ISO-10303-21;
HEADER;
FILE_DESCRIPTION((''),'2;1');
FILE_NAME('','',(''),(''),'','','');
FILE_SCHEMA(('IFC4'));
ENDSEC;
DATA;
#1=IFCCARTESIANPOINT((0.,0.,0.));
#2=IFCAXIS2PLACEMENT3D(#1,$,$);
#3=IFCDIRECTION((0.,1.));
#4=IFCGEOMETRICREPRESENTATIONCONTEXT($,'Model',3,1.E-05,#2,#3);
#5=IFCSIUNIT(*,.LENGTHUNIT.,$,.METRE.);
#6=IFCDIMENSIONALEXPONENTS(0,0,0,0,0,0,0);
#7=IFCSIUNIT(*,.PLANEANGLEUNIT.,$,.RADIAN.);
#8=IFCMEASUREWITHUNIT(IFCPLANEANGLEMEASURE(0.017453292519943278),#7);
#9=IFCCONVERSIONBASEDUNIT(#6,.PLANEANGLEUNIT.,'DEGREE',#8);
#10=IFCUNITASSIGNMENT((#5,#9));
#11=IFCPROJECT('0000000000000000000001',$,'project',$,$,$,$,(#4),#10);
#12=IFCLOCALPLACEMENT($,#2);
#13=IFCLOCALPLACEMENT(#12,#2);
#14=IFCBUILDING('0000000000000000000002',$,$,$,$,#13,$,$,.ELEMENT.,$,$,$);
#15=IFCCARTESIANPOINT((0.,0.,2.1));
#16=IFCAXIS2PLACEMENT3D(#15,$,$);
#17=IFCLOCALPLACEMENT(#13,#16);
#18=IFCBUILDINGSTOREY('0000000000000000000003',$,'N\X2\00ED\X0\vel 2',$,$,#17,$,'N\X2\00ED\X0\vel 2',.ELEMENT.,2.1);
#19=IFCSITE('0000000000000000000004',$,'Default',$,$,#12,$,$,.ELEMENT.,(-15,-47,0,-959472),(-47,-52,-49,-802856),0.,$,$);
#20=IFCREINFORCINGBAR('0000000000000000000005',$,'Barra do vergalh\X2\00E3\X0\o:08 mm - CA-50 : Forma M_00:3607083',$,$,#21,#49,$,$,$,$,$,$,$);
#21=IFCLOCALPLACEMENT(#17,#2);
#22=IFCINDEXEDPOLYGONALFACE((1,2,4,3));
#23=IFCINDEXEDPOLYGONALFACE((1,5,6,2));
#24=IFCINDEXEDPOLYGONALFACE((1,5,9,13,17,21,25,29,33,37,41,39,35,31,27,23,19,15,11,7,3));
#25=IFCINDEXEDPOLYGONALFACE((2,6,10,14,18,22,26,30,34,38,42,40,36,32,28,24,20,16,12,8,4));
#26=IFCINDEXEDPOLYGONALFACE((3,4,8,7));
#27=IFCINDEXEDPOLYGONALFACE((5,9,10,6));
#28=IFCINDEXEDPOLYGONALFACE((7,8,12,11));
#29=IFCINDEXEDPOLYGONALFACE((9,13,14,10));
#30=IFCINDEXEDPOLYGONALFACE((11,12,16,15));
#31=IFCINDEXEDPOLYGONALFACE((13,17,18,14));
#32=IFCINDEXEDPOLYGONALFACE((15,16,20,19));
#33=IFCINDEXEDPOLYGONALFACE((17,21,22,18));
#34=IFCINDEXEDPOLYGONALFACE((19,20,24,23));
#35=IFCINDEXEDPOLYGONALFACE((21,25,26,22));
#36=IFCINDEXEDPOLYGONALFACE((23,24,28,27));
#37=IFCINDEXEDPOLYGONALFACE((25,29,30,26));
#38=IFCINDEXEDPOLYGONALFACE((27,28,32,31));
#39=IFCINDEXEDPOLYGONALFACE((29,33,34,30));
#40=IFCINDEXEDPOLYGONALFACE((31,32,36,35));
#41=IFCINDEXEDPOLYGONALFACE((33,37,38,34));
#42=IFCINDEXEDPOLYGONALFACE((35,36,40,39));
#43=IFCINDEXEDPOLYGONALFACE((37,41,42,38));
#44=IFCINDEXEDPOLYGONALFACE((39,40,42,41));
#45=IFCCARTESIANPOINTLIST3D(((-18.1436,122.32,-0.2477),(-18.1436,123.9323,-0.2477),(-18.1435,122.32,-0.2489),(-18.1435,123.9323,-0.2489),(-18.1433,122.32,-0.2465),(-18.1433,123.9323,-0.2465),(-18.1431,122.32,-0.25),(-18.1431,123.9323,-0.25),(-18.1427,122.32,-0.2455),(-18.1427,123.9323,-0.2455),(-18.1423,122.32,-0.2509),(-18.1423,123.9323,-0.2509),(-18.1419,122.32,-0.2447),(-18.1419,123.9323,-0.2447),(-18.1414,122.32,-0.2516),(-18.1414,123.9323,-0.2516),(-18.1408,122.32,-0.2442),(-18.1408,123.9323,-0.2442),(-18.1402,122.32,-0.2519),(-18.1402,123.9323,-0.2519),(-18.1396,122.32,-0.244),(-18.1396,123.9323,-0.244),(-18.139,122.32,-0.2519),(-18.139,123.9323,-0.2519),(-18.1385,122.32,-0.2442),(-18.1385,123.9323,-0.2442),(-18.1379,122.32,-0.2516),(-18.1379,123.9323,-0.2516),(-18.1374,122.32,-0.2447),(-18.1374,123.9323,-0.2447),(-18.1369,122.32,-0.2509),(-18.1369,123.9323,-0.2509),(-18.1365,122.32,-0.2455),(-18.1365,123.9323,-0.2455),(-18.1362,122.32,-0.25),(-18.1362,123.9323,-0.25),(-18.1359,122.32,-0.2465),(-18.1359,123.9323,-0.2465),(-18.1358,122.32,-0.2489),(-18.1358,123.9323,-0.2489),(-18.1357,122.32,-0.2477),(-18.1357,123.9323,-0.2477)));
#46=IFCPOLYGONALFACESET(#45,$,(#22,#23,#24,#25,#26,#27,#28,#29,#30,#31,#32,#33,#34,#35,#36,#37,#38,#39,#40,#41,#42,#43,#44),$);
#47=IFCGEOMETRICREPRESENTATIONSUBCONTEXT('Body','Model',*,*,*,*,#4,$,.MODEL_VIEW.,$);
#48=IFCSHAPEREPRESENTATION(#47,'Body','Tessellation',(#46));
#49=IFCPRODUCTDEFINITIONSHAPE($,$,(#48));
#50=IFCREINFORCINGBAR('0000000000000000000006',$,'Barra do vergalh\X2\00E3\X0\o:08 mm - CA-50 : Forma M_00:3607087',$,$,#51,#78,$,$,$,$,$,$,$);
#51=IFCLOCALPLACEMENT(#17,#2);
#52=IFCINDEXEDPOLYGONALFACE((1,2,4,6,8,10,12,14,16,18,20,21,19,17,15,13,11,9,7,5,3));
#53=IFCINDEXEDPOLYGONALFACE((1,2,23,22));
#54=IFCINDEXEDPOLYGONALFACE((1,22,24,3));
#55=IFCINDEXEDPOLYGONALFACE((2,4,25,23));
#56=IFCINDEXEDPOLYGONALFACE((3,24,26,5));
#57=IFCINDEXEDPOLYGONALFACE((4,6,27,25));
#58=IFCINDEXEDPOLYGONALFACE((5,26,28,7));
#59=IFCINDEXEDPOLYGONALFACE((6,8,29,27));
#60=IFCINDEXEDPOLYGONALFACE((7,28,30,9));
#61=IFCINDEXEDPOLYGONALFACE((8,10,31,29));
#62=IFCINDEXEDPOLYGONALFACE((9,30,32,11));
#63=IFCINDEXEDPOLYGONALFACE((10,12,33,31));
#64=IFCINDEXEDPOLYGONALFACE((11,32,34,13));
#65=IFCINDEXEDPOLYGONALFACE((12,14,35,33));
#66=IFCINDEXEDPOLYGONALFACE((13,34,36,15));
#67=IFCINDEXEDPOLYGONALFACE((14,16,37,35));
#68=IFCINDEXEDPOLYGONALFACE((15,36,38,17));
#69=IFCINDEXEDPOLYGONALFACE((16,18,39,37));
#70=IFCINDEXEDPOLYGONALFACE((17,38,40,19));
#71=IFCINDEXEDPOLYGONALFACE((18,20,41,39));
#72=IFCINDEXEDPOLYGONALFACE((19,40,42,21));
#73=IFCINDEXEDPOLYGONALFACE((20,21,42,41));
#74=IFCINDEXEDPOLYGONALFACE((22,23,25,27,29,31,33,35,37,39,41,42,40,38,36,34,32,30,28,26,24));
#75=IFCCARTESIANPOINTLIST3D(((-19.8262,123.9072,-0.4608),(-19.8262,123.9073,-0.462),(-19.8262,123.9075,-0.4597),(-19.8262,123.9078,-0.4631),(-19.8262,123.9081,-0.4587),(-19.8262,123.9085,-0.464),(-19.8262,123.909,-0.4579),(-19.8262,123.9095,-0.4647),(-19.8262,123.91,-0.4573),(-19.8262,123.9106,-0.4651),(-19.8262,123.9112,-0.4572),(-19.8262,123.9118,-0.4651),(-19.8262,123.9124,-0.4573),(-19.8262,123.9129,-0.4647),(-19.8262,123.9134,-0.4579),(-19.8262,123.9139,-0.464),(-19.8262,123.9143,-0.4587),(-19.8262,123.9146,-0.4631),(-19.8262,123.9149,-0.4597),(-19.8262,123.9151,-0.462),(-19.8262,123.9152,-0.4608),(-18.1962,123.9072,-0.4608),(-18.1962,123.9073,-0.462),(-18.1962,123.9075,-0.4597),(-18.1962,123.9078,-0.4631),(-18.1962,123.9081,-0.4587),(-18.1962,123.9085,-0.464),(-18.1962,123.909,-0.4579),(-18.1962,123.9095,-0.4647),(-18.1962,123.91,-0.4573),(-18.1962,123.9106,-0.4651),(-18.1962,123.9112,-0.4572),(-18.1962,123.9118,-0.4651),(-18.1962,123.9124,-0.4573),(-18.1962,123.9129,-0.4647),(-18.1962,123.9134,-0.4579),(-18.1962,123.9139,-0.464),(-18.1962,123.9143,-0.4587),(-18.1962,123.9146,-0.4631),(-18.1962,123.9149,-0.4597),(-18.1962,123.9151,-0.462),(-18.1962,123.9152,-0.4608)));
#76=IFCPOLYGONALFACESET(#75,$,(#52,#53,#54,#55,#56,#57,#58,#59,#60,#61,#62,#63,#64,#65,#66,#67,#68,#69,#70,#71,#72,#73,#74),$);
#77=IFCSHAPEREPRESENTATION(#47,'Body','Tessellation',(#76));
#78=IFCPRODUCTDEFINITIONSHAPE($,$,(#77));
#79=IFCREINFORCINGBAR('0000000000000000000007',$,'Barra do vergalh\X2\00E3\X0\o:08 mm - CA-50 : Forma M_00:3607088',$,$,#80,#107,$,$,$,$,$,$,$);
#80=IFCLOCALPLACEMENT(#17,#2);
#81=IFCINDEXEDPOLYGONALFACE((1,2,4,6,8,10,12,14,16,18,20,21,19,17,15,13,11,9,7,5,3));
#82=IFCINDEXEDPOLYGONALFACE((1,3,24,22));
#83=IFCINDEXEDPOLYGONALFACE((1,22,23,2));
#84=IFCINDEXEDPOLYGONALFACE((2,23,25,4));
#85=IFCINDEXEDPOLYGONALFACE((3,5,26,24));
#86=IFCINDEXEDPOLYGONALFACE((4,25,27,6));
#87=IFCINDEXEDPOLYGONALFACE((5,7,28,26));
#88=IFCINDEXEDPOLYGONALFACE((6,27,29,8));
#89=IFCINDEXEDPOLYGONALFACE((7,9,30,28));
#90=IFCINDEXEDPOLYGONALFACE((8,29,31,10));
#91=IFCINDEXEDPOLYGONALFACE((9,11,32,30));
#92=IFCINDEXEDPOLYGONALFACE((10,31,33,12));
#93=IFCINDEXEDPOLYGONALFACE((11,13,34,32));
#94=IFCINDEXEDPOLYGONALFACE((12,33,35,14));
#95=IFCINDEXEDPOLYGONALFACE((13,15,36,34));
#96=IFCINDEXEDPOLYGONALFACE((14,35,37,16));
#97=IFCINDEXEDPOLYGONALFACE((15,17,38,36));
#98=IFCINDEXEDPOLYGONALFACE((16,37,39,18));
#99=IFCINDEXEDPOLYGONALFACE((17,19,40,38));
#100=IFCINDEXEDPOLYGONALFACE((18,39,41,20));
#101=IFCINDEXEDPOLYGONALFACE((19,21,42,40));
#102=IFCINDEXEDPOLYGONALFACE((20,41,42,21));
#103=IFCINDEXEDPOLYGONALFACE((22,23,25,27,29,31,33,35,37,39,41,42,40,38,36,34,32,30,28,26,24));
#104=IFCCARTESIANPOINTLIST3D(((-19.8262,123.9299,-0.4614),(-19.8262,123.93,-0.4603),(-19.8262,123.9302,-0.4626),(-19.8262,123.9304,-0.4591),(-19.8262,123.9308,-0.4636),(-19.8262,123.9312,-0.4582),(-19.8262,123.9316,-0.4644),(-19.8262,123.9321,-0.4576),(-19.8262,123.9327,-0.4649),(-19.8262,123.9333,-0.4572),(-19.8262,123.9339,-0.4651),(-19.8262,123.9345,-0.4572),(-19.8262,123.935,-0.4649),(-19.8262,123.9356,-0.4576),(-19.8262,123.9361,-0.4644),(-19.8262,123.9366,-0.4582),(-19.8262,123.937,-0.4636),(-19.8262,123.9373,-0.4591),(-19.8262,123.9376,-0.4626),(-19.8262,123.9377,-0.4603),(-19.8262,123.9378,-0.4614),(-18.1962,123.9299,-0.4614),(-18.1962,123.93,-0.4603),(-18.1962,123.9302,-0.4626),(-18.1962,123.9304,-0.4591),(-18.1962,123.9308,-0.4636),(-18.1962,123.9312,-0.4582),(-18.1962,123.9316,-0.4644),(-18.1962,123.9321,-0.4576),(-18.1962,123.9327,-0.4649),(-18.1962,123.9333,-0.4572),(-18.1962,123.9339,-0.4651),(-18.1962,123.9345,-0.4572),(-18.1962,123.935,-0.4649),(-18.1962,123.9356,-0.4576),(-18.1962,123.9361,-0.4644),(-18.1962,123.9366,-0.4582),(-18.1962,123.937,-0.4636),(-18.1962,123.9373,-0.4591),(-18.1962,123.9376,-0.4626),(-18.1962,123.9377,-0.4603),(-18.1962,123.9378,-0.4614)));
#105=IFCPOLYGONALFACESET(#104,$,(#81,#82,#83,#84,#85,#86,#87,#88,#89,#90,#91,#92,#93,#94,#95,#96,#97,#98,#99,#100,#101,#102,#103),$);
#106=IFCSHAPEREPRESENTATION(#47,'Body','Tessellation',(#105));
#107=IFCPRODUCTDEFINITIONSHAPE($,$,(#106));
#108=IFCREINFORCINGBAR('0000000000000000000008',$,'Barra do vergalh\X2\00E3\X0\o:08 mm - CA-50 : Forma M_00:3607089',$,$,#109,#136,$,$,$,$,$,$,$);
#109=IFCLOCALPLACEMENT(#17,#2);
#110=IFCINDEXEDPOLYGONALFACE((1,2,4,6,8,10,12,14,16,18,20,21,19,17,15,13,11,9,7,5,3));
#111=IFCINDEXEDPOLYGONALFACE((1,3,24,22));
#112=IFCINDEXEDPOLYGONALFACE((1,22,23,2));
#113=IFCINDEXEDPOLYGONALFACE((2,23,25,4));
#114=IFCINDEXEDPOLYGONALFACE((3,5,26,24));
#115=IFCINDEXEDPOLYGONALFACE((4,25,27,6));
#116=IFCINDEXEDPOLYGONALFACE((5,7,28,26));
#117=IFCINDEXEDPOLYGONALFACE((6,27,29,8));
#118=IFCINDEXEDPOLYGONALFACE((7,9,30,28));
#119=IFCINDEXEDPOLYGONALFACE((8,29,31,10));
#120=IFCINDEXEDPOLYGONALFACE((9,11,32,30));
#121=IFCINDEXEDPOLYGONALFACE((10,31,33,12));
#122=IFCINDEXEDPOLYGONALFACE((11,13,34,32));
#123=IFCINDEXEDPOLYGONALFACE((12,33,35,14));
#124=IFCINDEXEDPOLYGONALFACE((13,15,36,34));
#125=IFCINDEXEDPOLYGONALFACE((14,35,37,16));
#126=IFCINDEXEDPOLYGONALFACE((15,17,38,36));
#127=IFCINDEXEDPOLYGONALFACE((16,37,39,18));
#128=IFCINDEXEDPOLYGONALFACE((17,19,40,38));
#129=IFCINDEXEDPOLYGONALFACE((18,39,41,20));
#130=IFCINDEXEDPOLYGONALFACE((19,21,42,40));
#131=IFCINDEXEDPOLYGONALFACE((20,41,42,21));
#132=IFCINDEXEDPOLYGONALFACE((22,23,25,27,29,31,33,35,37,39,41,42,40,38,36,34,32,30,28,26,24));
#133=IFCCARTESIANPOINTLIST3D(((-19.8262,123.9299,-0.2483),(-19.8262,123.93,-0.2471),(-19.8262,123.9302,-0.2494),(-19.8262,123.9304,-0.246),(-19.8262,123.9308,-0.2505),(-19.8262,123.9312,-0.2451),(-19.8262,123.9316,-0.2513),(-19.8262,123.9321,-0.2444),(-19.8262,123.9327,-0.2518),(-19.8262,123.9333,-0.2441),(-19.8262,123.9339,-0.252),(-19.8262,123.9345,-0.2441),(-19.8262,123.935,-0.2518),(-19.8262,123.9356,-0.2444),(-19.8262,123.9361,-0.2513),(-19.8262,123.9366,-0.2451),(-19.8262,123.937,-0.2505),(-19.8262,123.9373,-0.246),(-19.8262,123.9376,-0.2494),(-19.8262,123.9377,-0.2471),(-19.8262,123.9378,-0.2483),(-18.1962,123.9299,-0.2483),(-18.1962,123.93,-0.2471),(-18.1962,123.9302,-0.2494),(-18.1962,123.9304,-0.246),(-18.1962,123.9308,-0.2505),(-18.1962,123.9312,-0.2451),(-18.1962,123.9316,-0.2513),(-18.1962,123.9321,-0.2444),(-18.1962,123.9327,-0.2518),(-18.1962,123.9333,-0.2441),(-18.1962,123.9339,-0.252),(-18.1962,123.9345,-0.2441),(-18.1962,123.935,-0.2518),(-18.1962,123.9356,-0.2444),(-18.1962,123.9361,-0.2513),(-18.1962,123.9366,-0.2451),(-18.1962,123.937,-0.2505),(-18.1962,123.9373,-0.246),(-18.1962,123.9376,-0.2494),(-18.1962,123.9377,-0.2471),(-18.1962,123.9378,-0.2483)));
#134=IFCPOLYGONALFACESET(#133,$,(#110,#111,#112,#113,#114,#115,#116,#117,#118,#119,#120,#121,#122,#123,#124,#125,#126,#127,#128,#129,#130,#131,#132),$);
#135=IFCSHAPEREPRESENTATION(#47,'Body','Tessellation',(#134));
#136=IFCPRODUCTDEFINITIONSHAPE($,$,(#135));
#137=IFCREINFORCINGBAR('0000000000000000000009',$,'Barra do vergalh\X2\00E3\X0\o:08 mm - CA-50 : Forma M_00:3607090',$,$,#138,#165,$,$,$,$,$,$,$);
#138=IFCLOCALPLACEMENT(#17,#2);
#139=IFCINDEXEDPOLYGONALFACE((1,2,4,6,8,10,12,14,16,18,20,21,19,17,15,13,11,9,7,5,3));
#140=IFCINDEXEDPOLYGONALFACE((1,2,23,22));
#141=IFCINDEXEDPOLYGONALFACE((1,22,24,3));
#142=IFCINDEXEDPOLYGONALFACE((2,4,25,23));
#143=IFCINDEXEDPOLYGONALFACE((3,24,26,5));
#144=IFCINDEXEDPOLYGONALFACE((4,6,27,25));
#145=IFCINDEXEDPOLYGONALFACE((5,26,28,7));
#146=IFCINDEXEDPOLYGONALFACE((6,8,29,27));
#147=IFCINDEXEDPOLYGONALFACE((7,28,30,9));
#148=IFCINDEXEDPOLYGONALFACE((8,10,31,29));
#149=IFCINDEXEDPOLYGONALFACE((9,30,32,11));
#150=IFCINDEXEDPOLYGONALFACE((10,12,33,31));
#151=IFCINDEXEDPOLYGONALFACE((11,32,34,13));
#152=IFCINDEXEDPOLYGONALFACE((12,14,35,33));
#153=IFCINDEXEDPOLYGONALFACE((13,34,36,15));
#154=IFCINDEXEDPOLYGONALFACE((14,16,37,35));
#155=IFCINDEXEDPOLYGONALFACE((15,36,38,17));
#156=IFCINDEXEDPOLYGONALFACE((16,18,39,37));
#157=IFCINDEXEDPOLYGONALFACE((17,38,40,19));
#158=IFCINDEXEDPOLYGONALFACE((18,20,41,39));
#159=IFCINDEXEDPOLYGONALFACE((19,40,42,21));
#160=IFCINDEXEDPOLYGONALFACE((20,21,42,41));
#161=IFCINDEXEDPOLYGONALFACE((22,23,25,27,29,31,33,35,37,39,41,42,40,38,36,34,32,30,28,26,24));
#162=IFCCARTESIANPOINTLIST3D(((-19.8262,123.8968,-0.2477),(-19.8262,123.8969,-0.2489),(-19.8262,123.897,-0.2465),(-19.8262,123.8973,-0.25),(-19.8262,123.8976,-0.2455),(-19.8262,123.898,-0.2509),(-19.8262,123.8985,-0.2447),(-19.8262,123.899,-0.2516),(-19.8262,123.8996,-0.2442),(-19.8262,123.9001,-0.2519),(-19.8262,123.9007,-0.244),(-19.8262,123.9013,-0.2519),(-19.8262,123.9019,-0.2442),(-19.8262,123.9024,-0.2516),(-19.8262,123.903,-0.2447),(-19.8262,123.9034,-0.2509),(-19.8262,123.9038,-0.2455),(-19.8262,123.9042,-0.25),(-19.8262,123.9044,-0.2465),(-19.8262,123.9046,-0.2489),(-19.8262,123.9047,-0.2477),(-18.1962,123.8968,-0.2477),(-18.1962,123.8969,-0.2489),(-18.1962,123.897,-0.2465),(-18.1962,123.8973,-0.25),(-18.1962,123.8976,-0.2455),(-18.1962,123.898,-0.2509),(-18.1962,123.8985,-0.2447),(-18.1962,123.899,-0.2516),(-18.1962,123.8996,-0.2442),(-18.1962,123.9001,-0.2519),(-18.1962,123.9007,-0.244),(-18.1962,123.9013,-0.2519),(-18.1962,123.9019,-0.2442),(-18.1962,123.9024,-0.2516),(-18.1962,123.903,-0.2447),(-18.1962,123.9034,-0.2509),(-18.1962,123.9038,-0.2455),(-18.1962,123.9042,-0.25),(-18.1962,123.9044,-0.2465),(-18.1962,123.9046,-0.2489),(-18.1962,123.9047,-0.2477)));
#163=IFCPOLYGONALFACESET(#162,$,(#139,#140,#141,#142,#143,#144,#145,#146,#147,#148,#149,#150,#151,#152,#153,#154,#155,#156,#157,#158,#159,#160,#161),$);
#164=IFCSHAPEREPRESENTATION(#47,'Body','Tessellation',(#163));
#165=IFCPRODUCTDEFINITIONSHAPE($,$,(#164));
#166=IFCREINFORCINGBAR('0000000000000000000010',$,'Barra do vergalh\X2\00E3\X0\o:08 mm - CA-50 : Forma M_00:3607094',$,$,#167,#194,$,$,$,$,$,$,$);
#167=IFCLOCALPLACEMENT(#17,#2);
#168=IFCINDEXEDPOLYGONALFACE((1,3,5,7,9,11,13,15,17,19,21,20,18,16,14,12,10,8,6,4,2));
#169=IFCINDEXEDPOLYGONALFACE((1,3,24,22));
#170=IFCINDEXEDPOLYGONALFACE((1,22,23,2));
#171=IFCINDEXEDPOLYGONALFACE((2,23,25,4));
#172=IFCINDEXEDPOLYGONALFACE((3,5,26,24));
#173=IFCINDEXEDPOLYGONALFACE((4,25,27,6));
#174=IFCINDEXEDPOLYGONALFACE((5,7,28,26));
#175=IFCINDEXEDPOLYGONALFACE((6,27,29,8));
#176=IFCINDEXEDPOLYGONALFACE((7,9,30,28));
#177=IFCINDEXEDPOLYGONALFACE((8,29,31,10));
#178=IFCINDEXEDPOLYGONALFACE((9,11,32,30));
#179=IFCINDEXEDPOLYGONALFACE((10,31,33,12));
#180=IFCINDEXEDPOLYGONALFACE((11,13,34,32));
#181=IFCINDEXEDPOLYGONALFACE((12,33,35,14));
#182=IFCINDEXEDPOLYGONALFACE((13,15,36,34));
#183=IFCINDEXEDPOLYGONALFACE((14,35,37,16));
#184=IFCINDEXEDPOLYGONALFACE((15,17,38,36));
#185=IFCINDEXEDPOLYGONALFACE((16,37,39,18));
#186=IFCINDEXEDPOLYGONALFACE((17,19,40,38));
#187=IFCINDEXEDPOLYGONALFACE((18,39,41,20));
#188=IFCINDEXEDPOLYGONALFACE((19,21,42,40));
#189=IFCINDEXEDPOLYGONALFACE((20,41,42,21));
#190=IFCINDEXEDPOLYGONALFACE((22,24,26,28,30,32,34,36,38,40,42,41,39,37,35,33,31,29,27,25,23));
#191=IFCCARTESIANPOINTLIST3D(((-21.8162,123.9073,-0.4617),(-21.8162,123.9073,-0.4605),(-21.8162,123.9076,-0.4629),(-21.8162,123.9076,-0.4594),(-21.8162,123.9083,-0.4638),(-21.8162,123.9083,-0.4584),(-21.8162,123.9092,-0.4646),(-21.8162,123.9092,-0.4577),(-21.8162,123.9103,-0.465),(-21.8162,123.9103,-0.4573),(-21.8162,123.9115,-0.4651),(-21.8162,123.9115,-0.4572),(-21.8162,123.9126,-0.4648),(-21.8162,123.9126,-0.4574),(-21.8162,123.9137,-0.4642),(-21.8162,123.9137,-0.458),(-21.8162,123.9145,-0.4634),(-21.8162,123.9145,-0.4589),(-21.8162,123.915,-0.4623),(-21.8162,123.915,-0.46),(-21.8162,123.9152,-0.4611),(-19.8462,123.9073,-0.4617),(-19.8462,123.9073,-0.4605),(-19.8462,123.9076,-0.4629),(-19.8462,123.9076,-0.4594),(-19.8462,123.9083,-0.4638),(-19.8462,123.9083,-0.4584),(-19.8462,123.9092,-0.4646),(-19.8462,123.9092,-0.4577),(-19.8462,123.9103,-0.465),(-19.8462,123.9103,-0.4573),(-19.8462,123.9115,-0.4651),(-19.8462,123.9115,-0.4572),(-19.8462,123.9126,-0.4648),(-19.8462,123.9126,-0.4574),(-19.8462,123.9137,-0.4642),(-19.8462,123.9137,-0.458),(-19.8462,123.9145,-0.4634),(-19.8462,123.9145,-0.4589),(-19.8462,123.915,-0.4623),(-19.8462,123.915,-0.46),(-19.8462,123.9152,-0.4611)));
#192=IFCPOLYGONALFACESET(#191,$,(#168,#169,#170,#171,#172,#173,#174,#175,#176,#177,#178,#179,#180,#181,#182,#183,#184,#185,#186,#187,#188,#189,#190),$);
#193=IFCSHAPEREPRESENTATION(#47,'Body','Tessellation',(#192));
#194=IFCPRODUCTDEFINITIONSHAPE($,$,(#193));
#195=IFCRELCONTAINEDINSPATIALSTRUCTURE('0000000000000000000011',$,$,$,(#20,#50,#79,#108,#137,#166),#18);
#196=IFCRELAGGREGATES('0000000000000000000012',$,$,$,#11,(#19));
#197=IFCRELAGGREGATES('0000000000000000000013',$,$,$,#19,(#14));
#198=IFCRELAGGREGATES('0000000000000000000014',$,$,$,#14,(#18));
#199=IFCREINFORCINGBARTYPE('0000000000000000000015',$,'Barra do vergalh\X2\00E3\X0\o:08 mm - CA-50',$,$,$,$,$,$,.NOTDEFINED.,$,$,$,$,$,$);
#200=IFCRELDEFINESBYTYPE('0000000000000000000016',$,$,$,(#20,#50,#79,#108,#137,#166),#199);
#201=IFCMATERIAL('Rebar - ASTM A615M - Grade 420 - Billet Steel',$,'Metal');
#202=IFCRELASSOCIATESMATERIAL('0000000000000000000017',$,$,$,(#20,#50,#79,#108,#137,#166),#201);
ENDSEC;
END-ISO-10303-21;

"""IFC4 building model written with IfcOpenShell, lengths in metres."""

from ifc_helpers import new_model, entity, si_unit, converted_unit, direction, frame, origin, place, context, subcontext, project, spatial, material, type_object, element, save


model = new_model("IFC4")

# Units and contexts
model_context = context("Model", 3, precision=1e-05, world=origin(), true_north=direction((0.0, 1.0)))
body_context = subcontext(model_context, "Body", "Model", "MODEL_VIEW")
ifc_project = project(units=[si_unit("LENGTHUNIT", "METRE"), converted_unit("PLANEANGLEUNIT", "DEGREE", entity("IfcPlaneAngleMeasure", 0.017453292519943278), si_unit("PLANEANGLEUNIT", "RADIAN"), dimensions=[0, 0, 0, 0, 0, 0, 0])], contexts=[model_context])

# Site, building, storey
site_placement = place(None, origin())
site = spatial("IfcSite", under=ifc_project, at=site_placement, Name="Default", CompositionType="ELEMENT", RefLatitude=(-15, -47, 0, -959472), RefLongitude=(-47, -52, -49, -802856), RefElevation=0.0)
building_placement = place(site_placement, origin())
building = spatial("IfcBuilding", under=site, at=building_placement, CompositionType="ELEMENT")
storey_placement = place(building_placement, frame((0.0, 0.0, 2.1)))
storey = spatial("IfcBuildingStorey", under=building, at=storey_placement, Name="Nível 2", LongName="Nível 2", CompositionType="ELEMENT", Elevation=2.1)

# Reinforcing bars
ifc_material_1 = material(Name="Rebar - ASTM A615M - Grade 420 - Billet Steel", Category="Metal")
reinforcing_bar_type_1 = type_object("IfcReinforcingBarType", Name="Barra do vergalhão:08 mm - CA-50", PredefinedType="NOTDEFINED")
reinforcing_bar_1_placement = place(storey_placement, origin())
element("IfcReinforcingBar", 1, at=reinforcing_bar_1_placement, inside=storey, type_object=reinforcing_bar_type_1, material=ifc_material_1, Name="Barra do vergalhão:08 mm - CA-50 : Forma M_00:3607083", context=body_context, shape_type="AdvancedSweptSolid", body=[
    entity("IfcSweptDiskSolid", entity("IfcIndexedPolyCurve", entity("IfcCartesianPointList3D", [[18.1396, -123.9323, 0.248], [18.1396, -122.32, 0.248]]), None, False), 0.004, None, 0.0, 1.0),
])
reinforcing_bar_2_placement = place(storey_placement, origin())
element("IfcReinforcingBar", 2, at=reinforcing_bar_2_placement, inside=storey, type_object=reinforcing_bar_type_1, material=ifc_material_1, Name="Barra do vergalhão:08 mm - CA-50 : Forma M_00:3607087", context=body_context, shape_type="AdvancedSweptSolid", body=[
    entity("IfcSweptDiskSolid", entity("IfcIndexedPolyCurve", entity("IfcCartesianPointList3D", [[18.1962, -123.9112, 0.4611], [19.8262, -123.9112, 0.4611]]), None, False), 0.004, None, 0.0, 1.0),
])
reinforcing_bar_3_placement = place(storey_placement, origin())
element("IfcReinforcingBar", 3, at=reinforcing_bar_3_placement, inside=storey, type_object=reinforcing_bar_type_1, material=ifc_material_1, Name="Barra do vergalhão:08 mm - CA-50 : Forma M_00:3607088", context=body_context, shape_type="AdvancedSweptSolid", body=[
    entity("IfcSweptDiskSolid", entity("IfcIndexedPolyCurve", entity("IfcCartesianPointList3D", [[19.8262, -123.9339, 0.4611], [18.1962, -123.9339, 0.4611]]), None, False), 0.004, None, 0.0, 1.0),
])
reinforcing_bar_4_placement = place(storey_placement, origin())
element("IfcReinforcingBar", 4, at=reinforcing_bar_4_placement, inside=storey, type_object=reinforcing_bar_type_1, material=ifc_material_1, Name="Barra do vergalhão:08 mm - CA-50 : Forma M_00:3607089", context=body_context, shape_type="AdvancedSweptSolid", body=[
    entity("IfcSweptDiskSolid", entity("IfcIndexedPolyCurve", entity("IfcCartesianPointList3D", [[19.8262, -123.9339, 0.248], [18.1962, -123.9339, 0.248]]), None, False), 0.004, None, 0.0, 1.0),
])
reinforcing_bar_5_placement = place(storey_placement, origin())
element("IfcReinforcingBar", 5, at=reinforcing_bar_5_placement, inside=storey, type_object=reinforcing_bar_type_1, material=ifc_material_1, Name="Barra do vergalhão:08 mm - CA-50 : Forma M_00:3607090", context=body_context, shape_type="AdvancedSweptSolid", body=[
    entity("IfcSweptDiskSolid", entity("IfcIndexedPolyCurve", entity("IfcCartesianPointList3D", [[18.1962, -123.9007, 0.248], [19.8262, -123.9007, 0.248]]), None, False), 0.004, None, 0.0, 1.0),
])
reinforcing_bar_6_placement = place(storey_placement, origin())
element("IfcReinforcingBar", 6, at=reinforcing_bar_6_placement, inside=storey, type_object=reinforcing_bar_type_1, material=ifc_material_1, Name="Barra do vergalhão:08 mm - CA-50 : Forma M_00:3607094", context=body_context, shape_type="AdvancedSweptSolid", body=[
    entity("IfcSweptDiskSolid", entity("IfcIndexedPolyCurve", entity("IfcCartesianPointList3D", [[19.8462, -123.9112, 0.4611], [21.8162, -123.9112, 0.4611]]), None, False), 0.004, None, 0.0, 1.0),
])

save(model, "model.ifc")
